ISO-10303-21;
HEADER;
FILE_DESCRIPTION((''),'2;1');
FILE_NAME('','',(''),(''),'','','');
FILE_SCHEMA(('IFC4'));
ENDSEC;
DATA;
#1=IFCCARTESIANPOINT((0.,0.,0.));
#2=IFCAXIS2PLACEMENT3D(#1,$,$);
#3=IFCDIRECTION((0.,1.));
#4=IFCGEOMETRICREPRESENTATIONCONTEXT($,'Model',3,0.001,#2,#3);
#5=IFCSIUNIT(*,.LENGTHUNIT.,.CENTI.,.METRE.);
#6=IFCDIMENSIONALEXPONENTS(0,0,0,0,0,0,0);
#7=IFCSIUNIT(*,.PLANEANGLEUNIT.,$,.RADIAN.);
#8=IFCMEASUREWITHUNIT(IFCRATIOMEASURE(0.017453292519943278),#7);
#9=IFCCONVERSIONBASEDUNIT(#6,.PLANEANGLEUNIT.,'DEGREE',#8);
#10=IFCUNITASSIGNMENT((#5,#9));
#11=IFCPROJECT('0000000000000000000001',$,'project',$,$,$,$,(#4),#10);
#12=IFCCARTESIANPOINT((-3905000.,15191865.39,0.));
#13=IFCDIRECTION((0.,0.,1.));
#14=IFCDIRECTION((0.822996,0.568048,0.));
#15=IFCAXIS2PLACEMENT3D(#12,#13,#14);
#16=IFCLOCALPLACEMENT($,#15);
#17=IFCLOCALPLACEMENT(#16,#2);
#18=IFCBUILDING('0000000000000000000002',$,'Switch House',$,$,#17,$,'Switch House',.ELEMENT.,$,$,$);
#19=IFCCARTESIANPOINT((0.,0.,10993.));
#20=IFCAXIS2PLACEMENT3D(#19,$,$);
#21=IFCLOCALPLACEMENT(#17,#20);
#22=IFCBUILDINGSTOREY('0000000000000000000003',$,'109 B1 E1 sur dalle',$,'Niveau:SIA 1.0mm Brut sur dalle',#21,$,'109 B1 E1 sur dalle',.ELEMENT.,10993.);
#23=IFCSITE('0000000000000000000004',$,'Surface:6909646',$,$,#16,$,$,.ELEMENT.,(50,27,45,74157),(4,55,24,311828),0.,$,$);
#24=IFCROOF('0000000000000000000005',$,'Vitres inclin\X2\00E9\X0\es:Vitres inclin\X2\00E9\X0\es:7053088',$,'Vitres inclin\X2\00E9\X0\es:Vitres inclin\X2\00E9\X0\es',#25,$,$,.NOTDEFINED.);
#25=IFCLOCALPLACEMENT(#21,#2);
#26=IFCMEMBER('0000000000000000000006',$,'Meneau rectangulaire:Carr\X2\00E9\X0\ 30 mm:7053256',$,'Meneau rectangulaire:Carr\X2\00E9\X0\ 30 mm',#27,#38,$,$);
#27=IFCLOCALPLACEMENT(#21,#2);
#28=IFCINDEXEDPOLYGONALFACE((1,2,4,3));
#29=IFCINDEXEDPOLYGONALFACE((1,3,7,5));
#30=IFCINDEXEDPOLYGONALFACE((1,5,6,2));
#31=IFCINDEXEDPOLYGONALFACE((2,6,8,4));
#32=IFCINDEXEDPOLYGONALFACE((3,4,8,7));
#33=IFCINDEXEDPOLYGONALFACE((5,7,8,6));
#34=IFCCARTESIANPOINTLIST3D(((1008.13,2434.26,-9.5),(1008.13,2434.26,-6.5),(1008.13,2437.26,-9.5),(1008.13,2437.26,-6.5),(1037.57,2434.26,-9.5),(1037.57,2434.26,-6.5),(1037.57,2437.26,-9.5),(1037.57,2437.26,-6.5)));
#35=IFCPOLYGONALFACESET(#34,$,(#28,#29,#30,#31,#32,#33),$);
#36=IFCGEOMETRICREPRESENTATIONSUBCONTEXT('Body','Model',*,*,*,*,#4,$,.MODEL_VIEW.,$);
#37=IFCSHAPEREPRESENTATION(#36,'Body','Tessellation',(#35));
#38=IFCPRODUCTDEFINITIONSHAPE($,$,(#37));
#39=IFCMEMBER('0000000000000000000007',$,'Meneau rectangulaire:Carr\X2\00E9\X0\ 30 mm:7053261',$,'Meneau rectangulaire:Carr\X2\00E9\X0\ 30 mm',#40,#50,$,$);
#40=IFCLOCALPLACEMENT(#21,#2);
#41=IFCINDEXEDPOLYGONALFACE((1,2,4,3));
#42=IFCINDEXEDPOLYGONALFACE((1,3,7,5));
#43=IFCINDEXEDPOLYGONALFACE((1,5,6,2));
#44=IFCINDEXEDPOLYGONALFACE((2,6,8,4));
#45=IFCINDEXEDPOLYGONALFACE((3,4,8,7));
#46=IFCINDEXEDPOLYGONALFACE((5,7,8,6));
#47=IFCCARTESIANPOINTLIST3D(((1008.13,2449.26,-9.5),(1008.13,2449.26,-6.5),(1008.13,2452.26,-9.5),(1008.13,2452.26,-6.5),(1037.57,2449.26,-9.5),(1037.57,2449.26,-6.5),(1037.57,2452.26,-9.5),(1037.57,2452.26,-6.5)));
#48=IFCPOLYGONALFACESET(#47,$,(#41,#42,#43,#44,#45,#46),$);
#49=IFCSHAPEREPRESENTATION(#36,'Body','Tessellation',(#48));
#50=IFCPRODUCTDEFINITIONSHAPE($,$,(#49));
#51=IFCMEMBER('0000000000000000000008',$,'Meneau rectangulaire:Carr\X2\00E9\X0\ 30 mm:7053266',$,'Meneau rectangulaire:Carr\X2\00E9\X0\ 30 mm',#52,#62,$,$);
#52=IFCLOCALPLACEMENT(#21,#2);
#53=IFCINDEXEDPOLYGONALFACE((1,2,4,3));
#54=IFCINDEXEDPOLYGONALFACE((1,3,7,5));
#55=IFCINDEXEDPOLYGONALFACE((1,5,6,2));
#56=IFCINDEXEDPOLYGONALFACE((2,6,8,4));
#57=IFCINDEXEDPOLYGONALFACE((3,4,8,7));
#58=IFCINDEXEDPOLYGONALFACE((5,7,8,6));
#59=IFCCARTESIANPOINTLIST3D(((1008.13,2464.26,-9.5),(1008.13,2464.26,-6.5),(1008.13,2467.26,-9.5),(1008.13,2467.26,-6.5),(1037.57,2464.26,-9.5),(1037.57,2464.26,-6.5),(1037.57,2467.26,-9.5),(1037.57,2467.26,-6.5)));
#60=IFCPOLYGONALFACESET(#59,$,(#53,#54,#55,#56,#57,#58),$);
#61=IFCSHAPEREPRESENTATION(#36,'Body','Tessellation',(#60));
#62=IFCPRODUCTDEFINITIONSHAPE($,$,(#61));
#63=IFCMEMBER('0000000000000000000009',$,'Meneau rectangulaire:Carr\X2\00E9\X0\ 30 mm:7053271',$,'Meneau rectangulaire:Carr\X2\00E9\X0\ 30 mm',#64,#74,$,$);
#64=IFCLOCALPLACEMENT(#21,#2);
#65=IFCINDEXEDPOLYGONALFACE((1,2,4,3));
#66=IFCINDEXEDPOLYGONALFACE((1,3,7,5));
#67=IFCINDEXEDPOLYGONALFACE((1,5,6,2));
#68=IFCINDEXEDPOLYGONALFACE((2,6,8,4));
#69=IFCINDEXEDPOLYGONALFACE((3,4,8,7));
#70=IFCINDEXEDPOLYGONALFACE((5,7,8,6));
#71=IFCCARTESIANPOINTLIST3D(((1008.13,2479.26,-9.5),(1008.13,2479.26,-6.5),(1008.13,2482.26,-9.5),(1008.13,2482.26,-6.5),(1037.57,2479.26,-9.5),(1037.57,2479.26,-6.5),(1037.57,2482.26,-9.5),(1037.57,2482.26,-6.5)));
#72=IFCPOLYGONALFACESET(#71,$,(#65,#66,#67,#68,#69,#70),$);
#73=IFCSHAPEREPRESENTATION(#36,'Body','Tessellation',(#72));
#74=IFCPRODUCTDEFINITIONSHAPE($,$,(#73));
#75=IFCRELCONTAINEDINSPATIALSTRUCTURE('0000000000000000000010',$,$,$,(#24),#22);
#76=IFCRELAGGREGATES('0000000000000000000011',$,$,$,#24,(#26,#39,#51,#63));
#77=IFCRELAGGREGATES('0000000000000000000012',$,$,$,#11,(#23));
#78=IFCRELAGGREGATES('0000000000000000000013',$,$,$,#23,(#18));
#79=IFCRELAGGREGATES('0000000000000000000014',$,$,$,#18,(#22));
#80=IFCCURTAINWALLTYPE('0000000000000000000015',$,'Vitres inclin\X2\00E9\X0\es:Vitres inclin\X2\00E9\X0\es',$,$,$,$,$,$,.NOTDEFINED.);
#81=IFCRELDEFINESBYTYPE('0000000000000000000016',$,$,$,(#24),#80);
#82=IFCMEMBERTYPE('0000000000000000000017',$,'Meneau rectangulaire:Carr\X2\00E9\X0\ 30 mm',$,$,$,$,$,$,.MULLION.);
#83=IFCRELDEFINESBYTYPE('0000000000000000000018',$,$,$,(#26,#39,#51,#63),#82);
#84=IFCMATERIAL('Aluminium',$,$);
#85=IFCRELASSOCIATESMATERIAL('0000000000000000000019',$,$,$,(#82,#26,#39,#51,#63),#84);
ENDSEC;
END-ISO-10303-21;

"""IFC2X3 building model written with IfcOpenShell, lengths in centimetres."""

from ifc_helpers import new_model, entity, si_unit, converted_unit, direction, frame, origin, origin_2d_with_axis, place, context, subcontext, project, spatial, rectangle, extrude, source, transform, mapped, material, type_object, type_shapes, element, aggregate, save


model = new_model("IFC2X3")

# Units and contexts
model_context = context("Model", 3, precision=0.001, world=origin(), true_north=direction((0.0, 1.0)))
body_context = subcontext(model_context, "Body", "Model", "MODEL_VIEW")
ifc_project = project(units=[si_unit("LENGTHUNIT", "METRE", prefix="CENTI"), converted_unit("PLANEANGLEUNIT", "DEGREE", entity("IfcRatioMeasure", 0.017453292519943278), si_unit("PLANEANGLEUNIT", "RADIAN"), dimensions=[0, 0, 0, 0, 0, 0, 0])], contexts=[model_context])

# Site, building, storey
site_placement = place(None, frame((-3905000.0, 15191865.39, 0.0), z_axis=(0.0, 0.0, 1.0), x_axis=(0.822996, 0.568048, 0.0)))
site = spatial("IfcSite", under=ifc_project, at=site_placement, Name="Surface:6909646", CompositionType="ELEMENT", RefLatitude=(50, 27, 45, 74157), RefLongitude=(4, 55, 24, 311828), RefElevation=0.0)
building_placement = place(site_placement, origin())
building = spatial("IfcBuilding", under=site, at=building_placement, Name="Switch House", LongName="Switch House", CompositionType="ELEMENT")
storey_placement = place(building_placement, frame((0.0, 0.0, 10993.0)))
storey = spatial("IfcBuildingStorey", under=building, at=storey_placement, Name="109 B1 E1 sur dalle", ObjectType="Niveau:SIA 1.0mm Brut sur dalle", LongName="109 B1 E1 sur dalle", CompositionType="ELEMENT", Elevation=10993.0)

# Roof, members
curtain_wall_type = type_object("IfcCurtainWallType", Name="Vitres inclinées:Vitres inclinées", PredefinedType="NOTDEFINED")
roof_placement = place(storey_placement, frame((0.0, 0.0, -10993.0)))
roof = element("IfcRoof", 1, at=roof_placement, inside=storey, type_object=curtain_wall_type, Name="Vitres inclinées:Vitres inclinées:7053088", ObjectType="Vitres inclinées:Vitres inclinées", ShapeType="NOTDEFINED")
ifc_material = material(Name="Aluminium")
member_type_1 = type_object("IfcMemberType", Name="Meneau rectangulaire:Carré 30 mm", PredefinedType="MULLION", material=ifc_material)
shared_shape_1 = source(origin(), body_context, "Body", "SweptSolid", [
    extrude(rectangle(XDim=3.0, YDim=3.0, at=origin_2d_with_axis()), frame((0.0, 0.0, -29.44), z_axis=(0.0, 0.0, 1.0), x_axis=(0.0, -1.0, 0.0)), (0.0, 0.0, 1.0), 29.44),
])
type_shapes(member_type_1, [shared_shape_1])
member_1_placement = place(roof_placement, frame((1008.13, 2435.76, 10985.0), z_axis=(-1.0, 0.0, 0.0), x_axis=(0.0, 1.0, 0.0)))
member_1 = element("IfcMember", 2, at=member_1_placement, type_object=member_type_1, material=ifc_material, Name="Meneau rectangulaire:Carré 30 mm:7053256", ObjectType="Meneau rectangulaire:Carré 30 mm", context=body_context, shape_type="MappedRepresentation", body=[
    mapped(shared_shape_1, transform((0.0, 0.0, 0.0), scale=1.0)),
])
member_2_placement = place(roof_placement, frame((1008.13, 2450.76, 10985.0), z_axis=(-1.0, 0.0, 0.0), x_axis=(0.0, 1.0, 0.0)))
member_2 = element("IfcMember", 3, at=member_2_placement, type_object=member_type_1, material=ifc_material, Name="Meneau rectangulaire:Carré 30 mm:7053261", ObjectType="Meneau rectangulaire:Carré 30 mm", context=body_context, shape_type="MappedRepresentation", body=[
    mapped(shared_shape_1, transform((0.0, 0.0, 0.0), scale=1.0)),
])
member_3_placement = place(roof_placement, frame((1008.13, 2465.76, 10985.0), z_axis=(-1.0, 0.0, 0.0), x_axis=(0.0, 1.0, 0.0)))
member_3 = element("IfcMember", 4, at=member_3_placement, type_object=member_type_1, material=ifc_material, Name="Meneau rectangulaire:Carré 30 mm:7053266", ObjectType="Meneau rectangulaire:Carré 30 mm", context=body_context, shape_type="MappedRepresentation", body=[
    mapped(shared_shape_1, transform((0.0, 0.0, 0.0), scale=1.0)),
])
member_4_placement = place(roof_placement, frame((1008.13, 2480.76, 10985.0), z_axis=(-1.0, 0.0, 0.0), x_axis=(0.0, 1.0, 0.0)))
member_4 = element("IfcMember", 5, at=member_4_placement, type_object=member_type_1, material=ifc_material, Name="Meneau rectangulaire:Carré 30 mm:7053271", ObjectType="Meneau rectangulaire:Carré 30 mm", context=body_context, shape_type="MappedRepresentation", body=[
    mapped(shared_shape_1, transform((0.0, 0.0, 0.0), scale=1.0)),
])
aggregate(roof, [member_1, member_2, member_3, member_4])

save(model, "model.ifc")
